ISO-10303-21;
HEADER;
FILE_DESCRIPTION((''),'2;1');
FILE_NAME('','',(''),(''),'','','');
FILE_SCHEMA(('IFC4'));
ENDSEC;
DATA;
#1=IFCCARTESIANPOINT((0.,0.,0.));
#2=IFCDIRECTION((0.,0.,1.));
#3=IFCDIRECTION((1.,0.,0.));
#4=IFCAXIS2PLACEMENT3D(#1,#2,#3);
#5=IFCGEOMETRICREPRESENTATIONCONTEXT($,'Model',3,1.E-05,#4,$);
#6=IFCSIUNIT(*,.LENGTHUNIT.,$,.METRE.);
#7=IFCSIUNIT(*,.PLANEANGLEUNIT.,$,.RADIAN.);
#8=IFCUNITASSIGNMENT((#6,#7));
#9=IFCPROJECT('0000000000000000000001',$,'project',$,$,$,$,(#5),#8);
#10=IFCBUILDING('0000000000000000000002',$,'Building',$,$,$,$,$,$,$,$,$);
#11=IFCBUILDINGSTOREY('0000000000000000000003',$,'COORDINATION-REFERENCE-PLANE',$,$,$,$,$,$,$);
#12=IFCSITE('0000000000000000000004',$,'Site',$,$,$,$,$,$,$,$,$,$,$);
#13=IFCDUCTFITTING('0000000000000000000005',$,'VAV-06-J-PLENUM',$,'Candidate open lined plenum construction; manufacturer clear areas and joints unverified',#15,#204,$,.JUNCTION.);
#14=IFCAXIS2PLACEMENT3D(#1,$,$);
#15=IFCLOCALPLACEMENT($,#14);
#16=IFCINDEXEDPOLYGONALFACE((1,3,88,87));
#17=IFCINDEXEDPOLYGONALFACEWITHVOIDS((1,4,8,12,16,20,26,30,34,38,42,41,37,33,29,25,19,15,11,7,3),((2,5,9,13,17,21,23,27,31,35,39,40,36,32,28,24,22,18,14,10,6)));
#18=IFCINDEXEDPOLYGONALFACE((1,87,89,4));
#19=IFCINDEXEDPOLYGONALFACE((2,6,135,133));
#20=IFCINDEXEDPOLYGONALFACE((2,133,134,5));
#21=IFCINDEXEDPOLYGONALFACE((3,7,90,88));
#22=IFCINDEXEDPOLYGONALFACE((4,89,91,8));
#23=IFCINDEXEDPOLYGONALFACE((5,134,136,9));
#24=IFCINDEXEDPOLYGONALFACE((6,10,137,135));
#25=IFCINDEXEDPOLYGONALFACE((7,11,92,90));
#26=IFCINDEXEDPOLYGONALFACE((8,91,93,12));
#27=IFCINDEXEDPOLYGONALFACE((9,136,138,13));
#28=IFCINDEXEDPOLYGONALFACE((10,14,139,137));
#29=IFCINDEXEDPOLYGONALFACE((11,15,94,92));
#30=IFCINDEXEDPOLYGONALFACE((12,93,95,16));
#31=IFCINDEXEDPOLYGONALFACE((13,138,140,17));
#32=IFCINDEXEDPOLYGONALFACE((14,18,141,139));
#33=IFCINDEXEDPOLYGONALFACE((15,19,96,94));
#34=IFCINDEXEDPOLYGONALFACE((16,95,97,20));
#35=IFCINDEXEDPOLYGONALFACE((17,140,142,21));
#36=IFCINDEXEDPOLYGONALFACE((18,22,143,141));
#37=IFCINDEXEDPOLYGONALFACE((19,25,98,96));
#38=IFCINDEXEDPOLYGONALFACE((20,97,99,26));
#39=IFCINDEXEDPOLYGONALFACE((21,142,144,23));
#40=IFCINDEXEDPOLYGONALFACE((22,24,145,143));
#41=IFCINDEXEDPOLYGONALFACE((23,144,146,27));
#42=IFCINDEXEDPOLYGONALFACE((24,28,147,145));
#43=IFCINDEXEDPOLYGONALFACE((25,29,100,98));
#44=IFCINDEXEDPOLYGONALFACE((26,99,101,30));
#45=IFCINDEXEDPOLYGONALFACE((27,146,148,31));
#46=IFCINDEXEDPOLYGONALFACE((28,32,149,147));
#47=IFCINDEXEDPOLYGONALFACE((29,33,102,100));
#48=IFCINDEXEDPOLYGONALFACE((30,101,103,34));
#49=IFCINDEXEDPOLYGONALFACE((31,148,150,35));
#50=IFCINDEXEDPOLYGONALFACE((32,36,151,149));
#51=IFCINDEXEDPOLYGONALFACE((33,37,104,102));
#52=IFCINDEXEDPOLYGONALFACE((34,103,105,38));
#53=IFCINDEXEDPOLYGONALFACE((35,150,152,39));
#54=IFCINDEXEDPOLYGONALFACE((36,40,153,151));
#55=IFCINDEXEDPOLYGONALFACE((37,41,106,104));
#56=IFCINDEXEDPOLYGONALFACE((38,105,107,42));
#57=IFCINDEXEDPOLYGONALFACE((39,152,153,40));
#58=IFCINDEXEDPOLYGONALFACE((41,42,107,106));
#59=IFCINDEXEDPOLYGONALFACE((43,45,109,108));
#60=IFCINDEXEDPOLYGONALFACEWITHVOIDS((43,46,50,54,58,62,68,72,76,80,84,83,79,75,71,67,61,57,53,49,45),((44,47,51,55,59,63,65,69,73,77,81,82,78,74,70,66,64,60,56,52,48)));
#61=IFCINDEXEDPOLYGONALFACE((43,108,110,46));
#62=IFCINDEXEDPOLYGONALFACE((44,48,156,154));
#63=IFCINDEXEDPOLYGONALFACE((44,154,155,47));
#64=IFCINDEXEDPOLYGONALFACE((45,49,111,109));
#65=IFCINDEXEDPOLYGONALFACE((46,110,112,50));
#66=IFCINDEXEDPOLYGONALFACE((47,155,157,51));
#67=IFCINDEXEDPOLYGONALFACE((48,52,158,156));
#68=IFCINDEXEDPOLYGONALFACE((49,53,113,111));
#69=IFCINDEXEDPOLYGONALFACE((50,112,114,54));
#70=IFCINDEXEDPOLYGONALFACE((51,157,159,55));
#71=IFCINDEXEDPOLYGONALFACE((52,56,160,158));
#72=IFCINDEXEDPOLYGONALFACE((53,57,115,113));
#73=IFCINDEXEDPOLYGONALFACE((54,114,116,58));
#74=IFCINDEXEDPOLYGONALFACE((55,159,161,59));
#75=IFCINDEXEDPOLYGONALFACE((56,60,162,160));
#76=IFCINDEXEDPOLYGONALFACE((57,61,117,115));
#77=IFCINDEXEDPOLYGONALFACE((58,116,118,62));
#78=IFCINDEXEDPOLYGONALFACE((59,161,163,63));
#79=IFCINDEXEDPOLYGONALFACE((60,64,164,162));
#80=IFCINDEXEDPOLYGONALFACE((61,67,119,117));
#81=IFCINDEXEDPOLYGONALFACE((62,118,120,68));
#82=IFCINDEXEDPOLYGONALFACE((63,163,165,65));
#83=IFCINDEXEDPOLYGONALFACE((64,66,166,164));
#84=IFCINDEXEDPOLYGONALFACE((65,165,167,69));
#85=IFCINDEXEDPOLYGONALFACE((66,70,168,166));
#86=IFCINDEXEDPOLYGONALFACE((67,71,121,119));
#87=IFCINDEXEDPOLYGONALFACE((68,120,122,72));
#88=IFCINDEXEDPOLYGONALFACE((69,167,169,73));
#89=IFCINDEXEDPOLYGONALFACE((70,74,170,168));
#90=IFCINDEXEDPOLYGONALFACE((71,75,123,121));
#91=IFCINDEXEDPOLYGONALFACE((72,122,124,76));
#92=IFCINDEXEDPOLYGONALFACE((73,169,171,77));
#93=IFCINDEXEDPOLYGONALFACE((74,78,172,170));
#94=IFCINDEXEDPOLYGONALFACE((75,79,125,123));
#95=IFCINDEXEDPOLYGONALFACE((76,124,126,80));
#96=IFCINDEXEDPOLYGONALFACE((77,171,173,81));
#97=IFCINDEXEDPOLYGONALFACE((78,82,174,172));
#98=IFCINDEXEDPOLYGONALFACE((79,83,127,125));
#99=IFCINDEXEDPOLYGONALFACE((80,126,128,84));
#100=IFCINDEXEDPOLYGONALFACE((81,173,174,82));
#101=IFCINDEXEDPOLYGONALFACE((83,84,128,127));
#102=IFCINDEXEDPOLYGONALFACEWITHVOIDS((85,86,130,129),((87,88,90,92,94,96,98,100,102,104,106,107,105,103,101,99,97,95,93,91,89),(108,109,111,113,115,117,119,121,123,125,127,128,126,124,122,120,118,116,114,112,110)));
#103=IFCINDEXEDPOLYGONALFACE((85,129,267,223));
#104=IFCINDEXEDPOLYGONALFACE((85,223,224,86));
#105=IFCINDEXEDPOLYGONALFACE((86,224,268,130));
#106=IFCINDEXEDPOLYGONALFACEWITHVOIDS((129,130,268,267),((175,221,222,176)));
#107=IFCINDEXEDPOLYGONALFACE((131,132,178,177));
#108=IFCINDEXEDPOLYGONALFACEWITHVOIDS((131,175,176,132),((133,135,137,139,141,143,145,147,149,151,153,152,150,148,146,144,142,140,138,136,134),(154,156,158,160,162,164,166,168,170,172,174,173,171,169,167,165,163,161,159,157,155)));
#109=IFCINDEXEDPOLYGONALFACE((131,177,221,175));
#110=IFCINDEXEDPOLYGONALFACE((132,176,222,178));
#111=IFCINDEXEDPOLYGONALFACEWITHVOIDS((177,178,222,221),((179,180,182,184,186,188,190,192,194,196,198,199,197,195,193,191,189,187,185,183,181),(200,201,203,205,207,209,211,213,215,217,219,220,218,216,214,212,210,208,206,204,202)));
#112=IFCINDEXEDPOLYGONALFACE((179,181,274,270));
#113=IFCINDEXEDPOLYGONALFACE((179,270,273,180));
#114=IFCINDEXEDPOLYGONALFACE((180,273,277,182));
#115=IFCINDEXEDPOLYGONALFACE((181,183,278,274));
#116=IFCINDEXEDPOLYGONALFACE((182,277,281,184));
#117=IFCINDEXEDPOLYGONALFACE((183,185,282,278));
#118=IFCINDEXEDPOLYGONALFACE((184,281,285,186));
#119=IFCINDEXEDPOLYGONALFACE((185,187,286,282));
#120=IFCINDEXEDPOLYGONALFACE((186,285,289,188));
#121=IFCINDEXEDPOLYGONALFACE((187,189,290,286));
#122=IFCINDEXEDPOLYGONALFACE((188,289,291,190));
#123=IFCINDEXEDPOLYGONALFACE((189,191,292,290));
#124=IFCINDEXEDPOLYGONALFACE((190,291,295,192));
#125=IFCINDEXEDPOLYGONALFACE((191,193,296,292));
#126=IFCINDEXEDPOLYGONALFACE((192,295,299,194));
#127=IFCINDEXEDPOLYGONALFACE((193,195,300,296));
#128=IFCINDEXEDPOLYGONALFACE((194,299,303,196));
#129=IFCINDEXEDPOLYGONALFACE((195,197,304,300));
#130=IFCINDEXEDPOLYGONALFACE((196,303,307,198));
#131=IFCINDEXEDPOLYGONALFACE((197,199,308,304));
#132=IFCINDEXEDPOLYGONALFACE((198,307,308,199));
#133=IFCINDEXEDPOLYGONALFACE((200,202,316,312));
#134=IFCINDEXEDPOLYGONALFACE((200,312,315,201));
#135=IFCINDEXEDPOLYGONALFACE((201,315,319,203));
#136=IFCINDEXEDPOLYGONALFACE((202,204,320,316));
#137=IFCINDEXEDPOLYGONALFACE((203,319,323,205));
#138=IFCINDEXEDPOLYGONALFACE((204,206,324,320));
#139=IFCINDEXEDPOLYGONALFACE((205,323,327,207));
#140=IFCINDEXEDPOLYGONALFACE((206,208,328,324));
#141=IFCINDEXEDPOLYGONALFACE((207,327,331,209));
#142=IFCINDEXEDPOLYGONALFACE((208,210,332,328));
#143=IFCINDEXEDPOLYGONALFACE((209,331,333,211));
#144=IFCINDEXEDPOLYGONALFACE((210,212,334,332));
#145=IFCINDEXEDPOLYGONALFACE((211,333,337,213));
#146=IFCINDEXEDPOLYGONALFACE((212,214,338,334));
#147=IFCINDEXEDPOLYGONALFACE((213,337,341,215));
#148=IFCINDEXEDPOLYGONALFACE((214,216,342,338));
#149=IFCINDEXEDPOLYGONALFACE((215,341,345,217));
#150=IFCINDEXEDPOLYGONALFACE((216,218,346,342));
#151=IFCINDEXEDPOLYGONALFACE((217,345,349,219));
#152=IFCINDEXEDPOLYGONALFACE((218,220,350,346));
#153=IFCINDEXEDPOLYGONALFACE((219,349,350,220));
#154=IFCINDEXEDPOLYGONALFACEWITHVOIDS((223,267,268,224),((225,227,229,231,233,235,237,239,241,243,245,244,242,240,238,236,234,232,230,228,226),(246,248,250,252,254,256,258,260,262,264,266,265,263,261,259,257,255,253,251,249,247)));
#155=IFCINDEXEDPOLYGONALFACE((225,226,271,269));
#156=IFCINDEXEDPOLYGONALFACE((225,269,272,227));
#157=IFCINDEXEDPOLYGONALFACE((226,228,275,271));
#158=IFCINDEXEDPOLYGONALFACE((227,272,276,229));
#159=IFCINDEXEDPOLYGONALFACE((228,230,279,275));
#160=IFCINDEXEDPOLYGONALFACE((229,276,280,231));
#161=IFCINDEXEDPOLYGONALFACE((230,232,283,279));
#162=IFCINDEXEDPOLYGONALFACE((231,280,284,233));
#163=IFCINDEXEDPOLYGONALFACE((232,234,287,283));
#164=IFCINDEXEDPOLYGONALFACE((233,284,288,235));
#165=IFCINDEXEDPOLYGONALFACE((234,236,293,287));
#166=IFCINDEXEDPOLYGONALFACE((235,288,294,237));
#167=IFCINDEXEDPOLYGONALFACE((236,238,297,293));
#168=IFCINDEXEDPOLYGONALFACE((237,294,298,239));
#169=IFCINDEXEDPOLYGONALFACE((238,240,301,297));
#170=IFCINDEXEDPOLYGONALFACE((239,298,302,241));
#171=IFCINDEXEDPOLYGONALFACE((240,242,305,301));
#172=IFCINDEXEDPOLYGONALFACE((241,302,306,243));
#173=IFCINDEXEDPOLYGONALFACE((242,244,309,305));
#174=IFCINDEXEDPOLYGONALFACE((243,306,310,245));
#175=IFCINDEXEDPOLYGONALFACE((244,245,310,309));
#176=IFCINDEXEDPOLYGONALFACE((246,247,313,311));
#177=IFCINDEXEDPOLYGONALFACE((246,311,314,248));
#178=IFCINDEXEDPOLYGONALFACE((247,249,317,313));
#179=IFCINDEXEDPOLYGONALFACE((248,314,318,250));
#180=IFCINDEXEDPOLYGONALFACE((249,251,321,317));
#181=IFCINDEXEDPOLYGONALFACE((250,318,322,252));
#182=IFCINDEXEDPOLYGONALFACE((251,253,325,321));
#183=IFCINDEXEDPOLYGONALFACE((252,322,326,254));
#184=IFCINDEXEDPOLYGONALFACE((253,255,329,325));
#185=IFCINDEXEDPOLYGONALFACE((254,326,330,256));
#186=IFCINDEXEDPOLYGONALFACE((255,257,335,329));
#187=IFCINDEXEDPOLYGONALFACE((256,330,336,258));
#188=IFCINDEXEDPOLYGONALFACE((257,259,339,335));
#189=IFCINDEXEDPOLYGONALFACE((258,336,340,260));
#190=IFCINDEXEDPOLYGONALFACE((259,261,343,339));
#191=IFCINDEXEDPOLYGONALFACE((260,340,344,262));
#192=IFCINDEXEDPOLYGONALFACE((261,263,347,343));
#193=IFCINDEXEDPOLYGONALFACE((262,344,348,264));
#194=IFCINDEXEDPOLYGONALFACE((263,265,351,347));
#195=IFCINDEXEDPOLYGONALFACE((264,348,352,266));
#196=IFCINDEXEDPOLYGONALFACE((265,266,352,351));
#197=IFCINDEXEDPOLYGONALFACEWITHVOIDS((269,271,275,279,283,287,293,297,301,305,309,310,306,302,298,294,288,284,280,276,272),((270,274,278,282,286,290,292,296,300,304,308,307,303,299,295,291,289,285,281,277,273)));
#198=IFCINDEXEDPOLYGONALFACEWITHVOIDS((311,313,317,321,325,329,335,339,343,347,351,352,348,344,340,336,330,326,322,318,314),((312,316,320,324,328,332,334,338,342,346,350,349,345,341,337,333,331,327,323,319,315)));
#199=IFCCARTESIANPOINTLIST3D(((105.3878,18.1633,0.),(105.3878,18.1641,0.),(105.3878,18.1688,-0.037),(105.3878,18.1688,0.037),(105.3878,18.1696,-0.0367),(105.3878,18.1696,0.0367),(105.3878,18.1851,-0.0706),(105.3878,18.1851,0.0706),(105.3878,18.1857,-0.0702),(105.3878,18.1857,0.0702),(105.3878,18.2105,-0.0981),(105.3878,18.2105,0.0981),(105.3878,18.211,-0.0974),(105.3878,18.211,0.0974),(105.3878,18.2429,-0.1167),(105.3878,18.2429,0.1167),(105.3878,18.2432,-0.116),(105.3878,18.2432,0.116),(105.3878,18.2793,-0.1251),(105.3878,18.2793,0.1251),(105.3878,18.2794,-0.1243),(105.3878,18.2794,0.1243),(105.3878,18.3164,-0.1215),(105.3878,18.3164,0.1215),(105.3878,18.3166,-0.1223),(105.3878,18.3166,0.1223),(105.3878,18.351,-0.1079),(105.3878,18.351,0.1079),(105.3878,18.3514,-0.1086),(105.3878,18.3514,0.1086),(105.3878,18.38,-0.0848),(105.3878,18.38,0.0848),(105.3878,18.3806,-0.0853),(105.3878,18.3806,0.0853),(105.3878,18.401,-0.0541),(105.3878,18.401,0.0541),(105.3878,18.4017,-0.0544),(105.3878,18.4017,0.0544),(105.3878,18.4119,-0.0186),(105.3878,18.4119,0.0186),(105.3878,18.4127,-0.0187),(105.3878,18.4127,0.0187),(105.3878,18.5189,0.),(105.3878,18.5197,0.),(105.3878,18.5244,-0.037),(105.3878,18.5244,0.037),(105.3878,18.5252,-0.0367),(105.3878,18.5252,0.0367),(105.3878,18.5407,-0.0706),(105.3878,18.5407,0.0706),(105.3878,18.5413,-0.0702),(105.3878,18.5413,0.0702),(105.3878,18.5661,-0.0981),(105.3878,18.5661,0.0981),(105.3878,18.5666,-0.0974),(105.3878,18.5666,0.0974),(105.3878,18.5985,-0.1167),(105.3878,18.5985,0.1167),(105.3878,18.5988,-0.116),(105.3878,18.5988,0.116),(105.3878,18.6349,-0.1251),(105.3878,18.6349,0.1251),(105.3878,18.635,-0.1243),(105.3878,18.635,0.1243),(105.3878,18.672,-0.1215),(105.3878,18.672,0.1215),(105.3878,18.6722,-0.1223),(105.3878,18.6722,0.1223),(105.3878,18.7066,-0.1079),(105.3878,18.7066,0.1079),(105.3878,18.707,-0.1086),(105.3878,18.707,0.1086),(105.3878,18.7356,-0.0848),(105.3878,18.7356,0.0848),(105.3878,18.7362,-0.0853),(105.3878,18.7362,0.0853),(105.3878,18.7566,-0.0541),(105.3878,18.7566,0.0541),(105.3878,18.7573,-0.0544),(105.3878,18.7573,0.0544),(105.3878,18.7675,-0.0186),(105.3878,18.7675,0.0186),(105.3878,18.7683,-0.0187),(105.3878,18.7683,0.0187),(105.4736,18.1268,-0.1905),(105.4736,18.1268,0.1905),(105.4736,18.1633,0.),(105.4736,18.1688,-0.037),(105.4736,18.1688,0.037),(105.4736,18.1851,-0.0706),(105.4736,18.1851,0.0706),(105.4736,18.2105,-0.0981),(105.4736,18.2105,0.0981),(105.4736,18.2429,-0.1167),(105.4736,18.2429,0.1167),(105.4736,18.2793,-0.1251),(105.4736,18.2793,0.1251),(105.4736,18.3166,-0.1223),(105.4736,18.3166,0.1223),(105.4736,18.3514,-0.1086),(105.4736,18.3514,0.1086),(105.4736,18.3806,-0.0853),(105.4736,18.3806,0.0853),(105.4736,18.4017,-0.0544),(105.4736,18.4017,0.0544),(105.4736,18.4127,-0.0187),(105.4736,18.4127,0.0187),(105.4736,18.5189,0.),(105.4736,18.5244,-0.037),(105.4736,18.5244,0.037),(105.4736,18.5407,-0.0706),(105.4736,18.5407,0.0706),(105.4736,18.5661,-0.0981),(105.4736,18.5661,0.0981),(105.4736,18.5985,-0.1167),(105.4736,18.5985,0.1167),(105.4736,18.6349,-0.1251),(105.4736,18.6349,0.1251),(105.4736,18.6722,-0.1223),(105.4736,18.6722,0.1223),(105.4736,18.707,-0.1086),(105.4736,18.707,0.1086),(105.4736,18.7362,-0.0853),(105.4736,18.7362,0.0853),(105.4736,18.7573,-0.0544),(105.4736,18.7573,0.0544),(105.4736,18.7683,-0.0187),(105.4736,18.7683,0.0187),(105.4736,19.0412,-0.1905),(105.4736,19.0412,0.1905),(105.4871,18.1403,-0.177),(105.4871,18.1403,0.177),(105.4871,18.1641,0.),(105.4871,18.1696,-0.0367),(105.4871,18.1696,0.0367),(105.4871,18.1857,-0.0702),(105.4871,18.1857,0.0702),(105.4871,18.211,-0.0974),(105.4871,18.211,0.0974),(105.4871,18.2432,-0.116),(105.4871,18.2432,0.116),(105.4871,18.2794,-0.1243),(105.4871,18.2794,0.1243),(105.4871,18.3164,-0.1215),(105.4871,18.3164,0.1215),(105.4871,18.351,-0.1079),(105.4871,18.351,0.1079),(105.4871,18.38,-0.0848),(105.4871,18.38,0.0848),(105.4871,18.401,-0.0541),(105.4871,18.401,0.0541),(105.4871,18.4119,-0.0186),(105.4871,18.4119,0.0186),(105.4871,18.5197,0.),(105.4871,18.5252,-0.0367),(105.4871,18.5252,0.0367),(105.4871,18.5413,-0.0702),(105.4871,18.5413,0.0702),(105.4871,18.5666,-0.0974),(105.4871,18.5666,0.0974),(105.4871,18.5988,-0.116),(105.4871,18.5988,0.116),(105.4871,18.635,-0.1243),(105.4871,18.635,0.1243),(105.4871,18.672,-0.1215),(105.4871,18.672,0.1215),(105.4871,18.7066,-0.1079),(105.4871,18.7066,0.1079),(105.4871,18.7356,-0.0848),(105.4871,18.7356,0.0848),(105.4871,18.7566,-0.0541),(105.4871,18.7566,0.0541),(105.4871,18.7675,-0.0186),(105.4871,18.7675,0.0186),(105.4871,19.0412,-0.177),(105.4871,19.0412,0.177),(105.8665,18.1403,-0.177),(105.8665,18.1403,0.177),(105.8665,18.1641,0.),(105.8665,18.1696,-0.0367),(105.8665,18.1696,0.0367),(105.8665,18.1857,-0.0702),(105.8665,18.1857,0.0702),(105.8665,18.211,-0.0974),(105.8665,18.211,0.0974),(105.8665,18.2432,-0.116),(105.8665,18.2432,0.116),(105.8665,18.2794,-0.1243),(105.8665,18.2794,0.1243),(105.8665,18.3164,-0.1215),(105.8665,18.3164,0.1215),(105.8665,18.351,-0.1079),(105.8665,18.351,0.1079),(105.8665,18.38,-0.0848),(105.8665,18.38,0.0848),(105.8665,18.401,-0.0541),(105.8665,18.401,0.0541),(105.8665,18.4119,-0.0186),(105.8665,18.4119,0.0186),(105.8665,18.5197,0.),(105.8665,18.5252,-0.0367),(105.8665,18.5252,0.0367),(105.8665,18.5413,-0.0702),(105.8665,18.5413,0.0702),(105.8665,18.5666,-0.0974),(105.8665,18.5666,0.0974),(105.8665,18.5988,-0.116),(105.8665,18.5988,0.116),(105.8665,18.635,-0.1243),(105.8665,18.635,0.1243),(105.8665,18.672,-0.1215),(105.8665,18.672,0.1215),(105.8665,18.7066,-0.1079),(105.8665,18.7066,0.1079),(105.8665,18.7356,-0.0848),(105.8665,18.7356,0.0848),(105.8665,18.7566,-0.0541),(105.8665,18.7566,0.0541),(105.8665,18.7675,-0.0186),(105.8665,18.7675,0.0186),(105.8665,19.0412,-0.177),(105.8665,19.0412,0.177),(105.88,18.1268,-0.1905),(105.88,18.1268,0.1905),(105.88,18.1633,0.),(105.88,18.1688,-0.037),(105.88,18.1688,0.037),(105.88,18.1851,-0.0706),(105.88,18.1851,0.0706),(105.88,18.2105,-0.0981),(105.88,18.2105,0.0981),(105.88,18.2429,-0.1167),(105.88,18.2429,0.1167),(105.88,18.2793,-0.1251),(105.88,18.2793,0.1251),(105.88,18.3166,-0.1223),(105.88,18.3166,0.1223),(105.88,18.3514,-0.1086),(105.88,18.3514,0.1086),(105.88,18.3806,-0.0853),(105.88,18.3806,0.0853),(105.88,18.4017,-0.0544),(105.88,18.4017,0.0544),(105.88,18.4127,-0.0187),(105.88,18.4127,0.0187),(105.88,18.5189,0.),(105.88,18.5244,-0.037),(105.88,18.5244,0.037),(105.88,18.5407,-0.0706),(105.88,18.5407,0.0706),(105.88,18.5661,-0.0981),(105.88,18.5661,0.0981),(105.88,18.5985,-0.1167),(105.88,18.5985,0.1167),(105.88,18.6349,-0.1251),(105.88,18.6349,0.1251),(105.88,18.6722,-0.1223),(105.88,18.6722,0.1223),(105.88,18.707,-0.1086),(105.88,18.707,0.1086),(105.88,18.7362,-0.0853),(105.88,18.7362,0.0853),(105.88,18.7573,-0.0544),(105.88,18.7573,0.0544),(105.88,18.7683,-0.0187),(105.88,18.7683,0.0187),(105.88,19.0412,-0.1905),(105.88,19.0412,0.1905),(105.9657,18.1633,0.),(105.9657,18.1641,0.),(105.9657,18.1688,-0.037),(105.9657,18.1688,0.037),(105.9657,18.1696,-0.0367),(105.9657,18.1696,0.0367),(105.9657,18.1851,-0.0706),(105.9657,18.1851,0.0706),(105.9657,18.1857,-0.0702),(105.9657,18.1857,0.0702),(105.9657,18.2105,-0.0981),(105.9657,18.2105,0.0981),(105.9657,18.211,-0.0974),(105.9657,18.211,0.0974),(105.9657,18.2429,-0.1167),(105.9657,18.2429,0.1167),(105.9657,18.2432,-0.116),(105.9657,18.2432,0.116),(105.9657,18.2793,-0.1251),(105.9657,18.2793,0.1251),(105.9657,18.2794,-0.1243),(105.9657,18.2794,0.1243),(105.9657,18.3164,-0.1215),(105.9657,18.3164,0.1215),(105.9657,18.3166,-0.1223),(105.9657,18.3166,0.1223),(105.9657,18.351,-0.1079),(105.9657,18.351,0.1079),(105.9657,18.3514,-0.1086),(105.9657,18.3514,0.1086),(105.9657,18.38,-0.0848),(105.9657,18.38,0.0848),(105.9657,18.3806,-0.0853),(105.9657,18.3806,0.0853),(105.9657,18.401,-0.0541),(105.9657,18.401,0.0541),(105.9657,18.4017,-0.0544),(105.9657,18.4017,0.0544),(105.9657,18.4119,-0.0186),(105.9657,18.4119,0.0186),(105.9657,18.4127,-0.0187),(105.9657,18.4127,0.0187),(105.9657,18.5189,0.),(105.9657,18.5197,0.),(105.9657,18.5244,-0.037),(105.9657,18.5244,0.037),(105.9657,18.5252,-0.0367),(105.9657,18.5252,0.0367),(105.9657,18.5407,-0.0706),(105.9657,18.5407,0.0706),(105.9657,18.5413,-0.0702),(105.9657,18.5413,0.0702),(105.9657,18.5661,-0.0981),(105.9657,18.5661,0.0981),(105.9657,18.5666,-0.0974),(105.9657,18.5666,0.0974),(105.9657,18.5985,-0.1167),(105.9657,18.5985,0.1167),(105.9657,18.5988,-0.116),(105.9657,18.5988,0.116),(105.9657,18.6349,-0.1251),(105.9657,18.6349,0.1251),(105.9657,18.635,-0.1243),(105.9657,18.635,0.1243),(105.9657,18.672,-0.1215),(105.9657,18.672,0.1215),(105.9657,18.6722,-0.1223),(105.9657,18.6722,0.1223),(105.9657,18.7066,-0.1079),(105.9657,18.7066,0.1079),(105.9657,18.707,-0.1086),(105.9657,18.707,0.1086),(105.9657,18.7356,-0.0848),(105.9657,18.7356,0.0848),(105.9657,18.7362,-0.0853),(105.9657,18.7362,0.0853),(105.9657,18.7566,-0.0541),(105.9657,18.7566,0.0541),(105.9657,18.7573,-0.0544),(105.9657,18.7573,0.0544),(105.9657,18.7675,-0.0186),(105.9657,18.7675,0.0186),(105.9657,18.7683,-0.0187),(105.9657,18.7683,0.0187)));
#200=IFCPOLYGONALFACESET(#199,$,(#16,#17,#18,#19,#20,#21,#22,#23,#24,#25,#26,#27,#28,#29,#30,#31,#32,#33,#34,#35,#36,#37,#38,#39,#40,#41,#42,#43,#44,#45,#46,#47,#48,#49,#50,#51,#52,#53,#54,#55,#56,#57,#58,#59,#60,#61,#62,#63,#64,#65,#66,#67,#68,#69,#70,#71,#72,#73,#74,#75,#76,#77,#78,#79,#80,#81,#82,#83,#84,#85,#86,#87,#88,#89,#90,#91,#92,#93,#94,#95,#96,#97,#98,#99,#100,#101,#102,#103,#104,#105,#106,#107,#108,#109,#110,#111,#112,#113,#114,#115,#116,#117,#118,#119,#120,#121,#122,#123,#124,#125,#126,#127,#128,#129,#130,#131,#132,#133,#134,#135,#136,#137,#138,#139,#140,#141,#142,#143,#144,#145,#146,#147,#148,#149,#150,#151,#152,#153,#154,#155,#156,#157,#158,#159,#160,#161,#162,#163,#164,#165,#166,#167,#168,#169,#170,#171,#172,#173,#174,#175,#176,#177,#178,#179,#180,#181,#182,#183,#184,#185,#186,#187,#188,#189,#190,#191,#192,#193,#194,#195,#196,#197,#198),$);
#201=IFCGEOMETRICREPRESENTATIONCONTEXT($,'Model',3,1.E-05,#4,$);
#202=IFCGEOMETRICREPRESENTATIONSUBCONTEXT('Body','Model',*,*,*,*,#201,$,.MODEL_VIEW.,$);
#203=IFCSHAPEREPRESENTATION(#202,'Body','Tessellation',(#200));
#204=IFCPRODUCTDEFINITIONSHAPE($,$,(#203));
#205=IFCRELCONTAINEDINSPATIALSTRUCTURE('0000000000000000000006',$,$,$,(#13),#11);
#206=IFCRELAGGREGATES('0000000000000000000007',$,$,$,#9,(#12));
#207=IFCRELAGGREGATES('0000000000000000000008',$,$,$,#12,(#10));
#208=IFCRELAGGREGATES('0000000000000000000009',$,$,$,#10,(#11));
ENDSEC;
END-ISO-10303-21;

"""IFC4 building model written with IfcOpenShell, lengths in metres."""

from ifc_helpers import new_model, si_unit, frame, origin_with_axes, place, context, subcontext, project, spatial, rectangle, circle, extrude, boolean, element, save


model = new_model("IFC4")

# Units and contexts
model_context_1 = context("Model", 3, precision=1e-05, world=origin_with_axes())
model_context_2 = context("Model", 3, precision=1e-05, world=origin_with_axes())
body_context_1 = subcontext(model_context_2, "Body", "Model", "MODEL_VIEW")
ifc_project = project(units=[si_unit("LENGTHUNIT", "METRE"), si_unit("PLANEANGLEUNIT", "RADIAN")], contexts=[model_context_1])

# Site, building, storey
site = spatial("IfcSite", under=ifc_project, Name="Site")
building = spatial("IfcBuilding", under=site, Name="Building")
storey = spatial("IfcBuildingStorey", under=building, Name="COORDINATION-REFERENCE-PLANE")

# Duct fitting
duct_fitting_1_placement = place(None, frame((105.4736, 18.1268, -0.1905), z_axis=(0.0, 0.0, 1.0), x_axis=(1.0, 0.0, 0.0)))
solid = boolean("UNION", boolean("UNION", boolean("UNION", boolean("UNION", extrude(rectangle(XDim=0.3794, YDim=0.354), frame((0.2032, 0.9244, 0.1905), z_axis=(0.0, -1.0, 0.0), x_axis=(1.0, 0.0, 0.0)), (0.0, 0.0, 1.0), 0.9109), extrude(circle(Radius=0.1246), frame((0.0235, 0.5175, 0.1905), z_axis=(-1.0, 0.0, 0.0), x_axis=(0.0, -1.0, 0.0)), (0.0, 0.0, 1.0), 0.1192)), extrude(circle(Radius=0.1246), frame((0.3829, 0.5175, 0.1905), z_axis=(1.0, 0.0, 0.0), x_axis=(0.0, -1.0, 0.0)), (0.0, 0.0, 1.0), 0.1192)), extrude(circle(Radius=0.1246), frame((0.0235, 0.1619, 0.1905), z_axis=(-1.0, 0.0, 0.0), x_axis=(0.0, -1.0, 0.0)), (0.0, 0.0, 1.0), 0.1192)), extrude(circle(Radius=0.1246), frame((0.3829, 0.1619, 0.1905), z_axis=(1.0, 0.0, 0.0), x_axis=(0.0, -1.0, 0.0)), (0.0, 0.0, 1.0), 0.1192))
element("IfcDuctFitting", 1, at=duct_fitting_1_placement, inside=storey, Name="VAV-06-J-PLENUM", ObjectType="Candidate open lined plenum construction; manufacturer clear areas and joints unverified", PredefinedType="JUNCTION", context=body_context_1, shape_type="CSG", body=[
    boolean("DIFFERENCE", boolean("UNION", boolean("UNION", boolean("UNION", boolean("UNION", extrude(rectangle(XDim=0.4064, YDim=0.381), frame((0.2032, 0.9144, 0.1905), z_axis=(0.0, -1.0, 0.0), x_axis=(1.0, 0.0, 0.0)), (0.0, 0.0, 1.0), 0.9144), extrude(circle(Radius=0.1254), frame((0.0235, 0.5175, 0.1905), z_axis=(-1.0, 0.0, 0.0), x_axis=(0.0, -1.0, 0.0)), (0.0, 0.0, 1.0), 0.1092)), extrude(circle(Radius=0.1254), frame((0.3829, 0.5175, 0.1905), z_axis=(1.0, 0.0, 0.0), x_axis=(0.0, -1.0, 0.0)), (0.0, 0.0, 1.0), 0.1092)), extrude(circle(Radius=0.1254), frame((0.0235, 0.1619, 0.1905), z_axis=(-1.0, 0.0, 0.0), x_axis=(0.0, -1.0, 0.0)), (0.0, 0.0, 1.0), 0.1092)), extrude(circle(Radius=0.1254), frame((0.3829, 0.1619, 0.1905), z_axis=(1.0, 0.0, 0.0), x_axis=(0.0, -1.0, 0.0)), (0.0, 0.0, 1.0), 0.1092)), solid),
])

save(model, "model.ifc")
